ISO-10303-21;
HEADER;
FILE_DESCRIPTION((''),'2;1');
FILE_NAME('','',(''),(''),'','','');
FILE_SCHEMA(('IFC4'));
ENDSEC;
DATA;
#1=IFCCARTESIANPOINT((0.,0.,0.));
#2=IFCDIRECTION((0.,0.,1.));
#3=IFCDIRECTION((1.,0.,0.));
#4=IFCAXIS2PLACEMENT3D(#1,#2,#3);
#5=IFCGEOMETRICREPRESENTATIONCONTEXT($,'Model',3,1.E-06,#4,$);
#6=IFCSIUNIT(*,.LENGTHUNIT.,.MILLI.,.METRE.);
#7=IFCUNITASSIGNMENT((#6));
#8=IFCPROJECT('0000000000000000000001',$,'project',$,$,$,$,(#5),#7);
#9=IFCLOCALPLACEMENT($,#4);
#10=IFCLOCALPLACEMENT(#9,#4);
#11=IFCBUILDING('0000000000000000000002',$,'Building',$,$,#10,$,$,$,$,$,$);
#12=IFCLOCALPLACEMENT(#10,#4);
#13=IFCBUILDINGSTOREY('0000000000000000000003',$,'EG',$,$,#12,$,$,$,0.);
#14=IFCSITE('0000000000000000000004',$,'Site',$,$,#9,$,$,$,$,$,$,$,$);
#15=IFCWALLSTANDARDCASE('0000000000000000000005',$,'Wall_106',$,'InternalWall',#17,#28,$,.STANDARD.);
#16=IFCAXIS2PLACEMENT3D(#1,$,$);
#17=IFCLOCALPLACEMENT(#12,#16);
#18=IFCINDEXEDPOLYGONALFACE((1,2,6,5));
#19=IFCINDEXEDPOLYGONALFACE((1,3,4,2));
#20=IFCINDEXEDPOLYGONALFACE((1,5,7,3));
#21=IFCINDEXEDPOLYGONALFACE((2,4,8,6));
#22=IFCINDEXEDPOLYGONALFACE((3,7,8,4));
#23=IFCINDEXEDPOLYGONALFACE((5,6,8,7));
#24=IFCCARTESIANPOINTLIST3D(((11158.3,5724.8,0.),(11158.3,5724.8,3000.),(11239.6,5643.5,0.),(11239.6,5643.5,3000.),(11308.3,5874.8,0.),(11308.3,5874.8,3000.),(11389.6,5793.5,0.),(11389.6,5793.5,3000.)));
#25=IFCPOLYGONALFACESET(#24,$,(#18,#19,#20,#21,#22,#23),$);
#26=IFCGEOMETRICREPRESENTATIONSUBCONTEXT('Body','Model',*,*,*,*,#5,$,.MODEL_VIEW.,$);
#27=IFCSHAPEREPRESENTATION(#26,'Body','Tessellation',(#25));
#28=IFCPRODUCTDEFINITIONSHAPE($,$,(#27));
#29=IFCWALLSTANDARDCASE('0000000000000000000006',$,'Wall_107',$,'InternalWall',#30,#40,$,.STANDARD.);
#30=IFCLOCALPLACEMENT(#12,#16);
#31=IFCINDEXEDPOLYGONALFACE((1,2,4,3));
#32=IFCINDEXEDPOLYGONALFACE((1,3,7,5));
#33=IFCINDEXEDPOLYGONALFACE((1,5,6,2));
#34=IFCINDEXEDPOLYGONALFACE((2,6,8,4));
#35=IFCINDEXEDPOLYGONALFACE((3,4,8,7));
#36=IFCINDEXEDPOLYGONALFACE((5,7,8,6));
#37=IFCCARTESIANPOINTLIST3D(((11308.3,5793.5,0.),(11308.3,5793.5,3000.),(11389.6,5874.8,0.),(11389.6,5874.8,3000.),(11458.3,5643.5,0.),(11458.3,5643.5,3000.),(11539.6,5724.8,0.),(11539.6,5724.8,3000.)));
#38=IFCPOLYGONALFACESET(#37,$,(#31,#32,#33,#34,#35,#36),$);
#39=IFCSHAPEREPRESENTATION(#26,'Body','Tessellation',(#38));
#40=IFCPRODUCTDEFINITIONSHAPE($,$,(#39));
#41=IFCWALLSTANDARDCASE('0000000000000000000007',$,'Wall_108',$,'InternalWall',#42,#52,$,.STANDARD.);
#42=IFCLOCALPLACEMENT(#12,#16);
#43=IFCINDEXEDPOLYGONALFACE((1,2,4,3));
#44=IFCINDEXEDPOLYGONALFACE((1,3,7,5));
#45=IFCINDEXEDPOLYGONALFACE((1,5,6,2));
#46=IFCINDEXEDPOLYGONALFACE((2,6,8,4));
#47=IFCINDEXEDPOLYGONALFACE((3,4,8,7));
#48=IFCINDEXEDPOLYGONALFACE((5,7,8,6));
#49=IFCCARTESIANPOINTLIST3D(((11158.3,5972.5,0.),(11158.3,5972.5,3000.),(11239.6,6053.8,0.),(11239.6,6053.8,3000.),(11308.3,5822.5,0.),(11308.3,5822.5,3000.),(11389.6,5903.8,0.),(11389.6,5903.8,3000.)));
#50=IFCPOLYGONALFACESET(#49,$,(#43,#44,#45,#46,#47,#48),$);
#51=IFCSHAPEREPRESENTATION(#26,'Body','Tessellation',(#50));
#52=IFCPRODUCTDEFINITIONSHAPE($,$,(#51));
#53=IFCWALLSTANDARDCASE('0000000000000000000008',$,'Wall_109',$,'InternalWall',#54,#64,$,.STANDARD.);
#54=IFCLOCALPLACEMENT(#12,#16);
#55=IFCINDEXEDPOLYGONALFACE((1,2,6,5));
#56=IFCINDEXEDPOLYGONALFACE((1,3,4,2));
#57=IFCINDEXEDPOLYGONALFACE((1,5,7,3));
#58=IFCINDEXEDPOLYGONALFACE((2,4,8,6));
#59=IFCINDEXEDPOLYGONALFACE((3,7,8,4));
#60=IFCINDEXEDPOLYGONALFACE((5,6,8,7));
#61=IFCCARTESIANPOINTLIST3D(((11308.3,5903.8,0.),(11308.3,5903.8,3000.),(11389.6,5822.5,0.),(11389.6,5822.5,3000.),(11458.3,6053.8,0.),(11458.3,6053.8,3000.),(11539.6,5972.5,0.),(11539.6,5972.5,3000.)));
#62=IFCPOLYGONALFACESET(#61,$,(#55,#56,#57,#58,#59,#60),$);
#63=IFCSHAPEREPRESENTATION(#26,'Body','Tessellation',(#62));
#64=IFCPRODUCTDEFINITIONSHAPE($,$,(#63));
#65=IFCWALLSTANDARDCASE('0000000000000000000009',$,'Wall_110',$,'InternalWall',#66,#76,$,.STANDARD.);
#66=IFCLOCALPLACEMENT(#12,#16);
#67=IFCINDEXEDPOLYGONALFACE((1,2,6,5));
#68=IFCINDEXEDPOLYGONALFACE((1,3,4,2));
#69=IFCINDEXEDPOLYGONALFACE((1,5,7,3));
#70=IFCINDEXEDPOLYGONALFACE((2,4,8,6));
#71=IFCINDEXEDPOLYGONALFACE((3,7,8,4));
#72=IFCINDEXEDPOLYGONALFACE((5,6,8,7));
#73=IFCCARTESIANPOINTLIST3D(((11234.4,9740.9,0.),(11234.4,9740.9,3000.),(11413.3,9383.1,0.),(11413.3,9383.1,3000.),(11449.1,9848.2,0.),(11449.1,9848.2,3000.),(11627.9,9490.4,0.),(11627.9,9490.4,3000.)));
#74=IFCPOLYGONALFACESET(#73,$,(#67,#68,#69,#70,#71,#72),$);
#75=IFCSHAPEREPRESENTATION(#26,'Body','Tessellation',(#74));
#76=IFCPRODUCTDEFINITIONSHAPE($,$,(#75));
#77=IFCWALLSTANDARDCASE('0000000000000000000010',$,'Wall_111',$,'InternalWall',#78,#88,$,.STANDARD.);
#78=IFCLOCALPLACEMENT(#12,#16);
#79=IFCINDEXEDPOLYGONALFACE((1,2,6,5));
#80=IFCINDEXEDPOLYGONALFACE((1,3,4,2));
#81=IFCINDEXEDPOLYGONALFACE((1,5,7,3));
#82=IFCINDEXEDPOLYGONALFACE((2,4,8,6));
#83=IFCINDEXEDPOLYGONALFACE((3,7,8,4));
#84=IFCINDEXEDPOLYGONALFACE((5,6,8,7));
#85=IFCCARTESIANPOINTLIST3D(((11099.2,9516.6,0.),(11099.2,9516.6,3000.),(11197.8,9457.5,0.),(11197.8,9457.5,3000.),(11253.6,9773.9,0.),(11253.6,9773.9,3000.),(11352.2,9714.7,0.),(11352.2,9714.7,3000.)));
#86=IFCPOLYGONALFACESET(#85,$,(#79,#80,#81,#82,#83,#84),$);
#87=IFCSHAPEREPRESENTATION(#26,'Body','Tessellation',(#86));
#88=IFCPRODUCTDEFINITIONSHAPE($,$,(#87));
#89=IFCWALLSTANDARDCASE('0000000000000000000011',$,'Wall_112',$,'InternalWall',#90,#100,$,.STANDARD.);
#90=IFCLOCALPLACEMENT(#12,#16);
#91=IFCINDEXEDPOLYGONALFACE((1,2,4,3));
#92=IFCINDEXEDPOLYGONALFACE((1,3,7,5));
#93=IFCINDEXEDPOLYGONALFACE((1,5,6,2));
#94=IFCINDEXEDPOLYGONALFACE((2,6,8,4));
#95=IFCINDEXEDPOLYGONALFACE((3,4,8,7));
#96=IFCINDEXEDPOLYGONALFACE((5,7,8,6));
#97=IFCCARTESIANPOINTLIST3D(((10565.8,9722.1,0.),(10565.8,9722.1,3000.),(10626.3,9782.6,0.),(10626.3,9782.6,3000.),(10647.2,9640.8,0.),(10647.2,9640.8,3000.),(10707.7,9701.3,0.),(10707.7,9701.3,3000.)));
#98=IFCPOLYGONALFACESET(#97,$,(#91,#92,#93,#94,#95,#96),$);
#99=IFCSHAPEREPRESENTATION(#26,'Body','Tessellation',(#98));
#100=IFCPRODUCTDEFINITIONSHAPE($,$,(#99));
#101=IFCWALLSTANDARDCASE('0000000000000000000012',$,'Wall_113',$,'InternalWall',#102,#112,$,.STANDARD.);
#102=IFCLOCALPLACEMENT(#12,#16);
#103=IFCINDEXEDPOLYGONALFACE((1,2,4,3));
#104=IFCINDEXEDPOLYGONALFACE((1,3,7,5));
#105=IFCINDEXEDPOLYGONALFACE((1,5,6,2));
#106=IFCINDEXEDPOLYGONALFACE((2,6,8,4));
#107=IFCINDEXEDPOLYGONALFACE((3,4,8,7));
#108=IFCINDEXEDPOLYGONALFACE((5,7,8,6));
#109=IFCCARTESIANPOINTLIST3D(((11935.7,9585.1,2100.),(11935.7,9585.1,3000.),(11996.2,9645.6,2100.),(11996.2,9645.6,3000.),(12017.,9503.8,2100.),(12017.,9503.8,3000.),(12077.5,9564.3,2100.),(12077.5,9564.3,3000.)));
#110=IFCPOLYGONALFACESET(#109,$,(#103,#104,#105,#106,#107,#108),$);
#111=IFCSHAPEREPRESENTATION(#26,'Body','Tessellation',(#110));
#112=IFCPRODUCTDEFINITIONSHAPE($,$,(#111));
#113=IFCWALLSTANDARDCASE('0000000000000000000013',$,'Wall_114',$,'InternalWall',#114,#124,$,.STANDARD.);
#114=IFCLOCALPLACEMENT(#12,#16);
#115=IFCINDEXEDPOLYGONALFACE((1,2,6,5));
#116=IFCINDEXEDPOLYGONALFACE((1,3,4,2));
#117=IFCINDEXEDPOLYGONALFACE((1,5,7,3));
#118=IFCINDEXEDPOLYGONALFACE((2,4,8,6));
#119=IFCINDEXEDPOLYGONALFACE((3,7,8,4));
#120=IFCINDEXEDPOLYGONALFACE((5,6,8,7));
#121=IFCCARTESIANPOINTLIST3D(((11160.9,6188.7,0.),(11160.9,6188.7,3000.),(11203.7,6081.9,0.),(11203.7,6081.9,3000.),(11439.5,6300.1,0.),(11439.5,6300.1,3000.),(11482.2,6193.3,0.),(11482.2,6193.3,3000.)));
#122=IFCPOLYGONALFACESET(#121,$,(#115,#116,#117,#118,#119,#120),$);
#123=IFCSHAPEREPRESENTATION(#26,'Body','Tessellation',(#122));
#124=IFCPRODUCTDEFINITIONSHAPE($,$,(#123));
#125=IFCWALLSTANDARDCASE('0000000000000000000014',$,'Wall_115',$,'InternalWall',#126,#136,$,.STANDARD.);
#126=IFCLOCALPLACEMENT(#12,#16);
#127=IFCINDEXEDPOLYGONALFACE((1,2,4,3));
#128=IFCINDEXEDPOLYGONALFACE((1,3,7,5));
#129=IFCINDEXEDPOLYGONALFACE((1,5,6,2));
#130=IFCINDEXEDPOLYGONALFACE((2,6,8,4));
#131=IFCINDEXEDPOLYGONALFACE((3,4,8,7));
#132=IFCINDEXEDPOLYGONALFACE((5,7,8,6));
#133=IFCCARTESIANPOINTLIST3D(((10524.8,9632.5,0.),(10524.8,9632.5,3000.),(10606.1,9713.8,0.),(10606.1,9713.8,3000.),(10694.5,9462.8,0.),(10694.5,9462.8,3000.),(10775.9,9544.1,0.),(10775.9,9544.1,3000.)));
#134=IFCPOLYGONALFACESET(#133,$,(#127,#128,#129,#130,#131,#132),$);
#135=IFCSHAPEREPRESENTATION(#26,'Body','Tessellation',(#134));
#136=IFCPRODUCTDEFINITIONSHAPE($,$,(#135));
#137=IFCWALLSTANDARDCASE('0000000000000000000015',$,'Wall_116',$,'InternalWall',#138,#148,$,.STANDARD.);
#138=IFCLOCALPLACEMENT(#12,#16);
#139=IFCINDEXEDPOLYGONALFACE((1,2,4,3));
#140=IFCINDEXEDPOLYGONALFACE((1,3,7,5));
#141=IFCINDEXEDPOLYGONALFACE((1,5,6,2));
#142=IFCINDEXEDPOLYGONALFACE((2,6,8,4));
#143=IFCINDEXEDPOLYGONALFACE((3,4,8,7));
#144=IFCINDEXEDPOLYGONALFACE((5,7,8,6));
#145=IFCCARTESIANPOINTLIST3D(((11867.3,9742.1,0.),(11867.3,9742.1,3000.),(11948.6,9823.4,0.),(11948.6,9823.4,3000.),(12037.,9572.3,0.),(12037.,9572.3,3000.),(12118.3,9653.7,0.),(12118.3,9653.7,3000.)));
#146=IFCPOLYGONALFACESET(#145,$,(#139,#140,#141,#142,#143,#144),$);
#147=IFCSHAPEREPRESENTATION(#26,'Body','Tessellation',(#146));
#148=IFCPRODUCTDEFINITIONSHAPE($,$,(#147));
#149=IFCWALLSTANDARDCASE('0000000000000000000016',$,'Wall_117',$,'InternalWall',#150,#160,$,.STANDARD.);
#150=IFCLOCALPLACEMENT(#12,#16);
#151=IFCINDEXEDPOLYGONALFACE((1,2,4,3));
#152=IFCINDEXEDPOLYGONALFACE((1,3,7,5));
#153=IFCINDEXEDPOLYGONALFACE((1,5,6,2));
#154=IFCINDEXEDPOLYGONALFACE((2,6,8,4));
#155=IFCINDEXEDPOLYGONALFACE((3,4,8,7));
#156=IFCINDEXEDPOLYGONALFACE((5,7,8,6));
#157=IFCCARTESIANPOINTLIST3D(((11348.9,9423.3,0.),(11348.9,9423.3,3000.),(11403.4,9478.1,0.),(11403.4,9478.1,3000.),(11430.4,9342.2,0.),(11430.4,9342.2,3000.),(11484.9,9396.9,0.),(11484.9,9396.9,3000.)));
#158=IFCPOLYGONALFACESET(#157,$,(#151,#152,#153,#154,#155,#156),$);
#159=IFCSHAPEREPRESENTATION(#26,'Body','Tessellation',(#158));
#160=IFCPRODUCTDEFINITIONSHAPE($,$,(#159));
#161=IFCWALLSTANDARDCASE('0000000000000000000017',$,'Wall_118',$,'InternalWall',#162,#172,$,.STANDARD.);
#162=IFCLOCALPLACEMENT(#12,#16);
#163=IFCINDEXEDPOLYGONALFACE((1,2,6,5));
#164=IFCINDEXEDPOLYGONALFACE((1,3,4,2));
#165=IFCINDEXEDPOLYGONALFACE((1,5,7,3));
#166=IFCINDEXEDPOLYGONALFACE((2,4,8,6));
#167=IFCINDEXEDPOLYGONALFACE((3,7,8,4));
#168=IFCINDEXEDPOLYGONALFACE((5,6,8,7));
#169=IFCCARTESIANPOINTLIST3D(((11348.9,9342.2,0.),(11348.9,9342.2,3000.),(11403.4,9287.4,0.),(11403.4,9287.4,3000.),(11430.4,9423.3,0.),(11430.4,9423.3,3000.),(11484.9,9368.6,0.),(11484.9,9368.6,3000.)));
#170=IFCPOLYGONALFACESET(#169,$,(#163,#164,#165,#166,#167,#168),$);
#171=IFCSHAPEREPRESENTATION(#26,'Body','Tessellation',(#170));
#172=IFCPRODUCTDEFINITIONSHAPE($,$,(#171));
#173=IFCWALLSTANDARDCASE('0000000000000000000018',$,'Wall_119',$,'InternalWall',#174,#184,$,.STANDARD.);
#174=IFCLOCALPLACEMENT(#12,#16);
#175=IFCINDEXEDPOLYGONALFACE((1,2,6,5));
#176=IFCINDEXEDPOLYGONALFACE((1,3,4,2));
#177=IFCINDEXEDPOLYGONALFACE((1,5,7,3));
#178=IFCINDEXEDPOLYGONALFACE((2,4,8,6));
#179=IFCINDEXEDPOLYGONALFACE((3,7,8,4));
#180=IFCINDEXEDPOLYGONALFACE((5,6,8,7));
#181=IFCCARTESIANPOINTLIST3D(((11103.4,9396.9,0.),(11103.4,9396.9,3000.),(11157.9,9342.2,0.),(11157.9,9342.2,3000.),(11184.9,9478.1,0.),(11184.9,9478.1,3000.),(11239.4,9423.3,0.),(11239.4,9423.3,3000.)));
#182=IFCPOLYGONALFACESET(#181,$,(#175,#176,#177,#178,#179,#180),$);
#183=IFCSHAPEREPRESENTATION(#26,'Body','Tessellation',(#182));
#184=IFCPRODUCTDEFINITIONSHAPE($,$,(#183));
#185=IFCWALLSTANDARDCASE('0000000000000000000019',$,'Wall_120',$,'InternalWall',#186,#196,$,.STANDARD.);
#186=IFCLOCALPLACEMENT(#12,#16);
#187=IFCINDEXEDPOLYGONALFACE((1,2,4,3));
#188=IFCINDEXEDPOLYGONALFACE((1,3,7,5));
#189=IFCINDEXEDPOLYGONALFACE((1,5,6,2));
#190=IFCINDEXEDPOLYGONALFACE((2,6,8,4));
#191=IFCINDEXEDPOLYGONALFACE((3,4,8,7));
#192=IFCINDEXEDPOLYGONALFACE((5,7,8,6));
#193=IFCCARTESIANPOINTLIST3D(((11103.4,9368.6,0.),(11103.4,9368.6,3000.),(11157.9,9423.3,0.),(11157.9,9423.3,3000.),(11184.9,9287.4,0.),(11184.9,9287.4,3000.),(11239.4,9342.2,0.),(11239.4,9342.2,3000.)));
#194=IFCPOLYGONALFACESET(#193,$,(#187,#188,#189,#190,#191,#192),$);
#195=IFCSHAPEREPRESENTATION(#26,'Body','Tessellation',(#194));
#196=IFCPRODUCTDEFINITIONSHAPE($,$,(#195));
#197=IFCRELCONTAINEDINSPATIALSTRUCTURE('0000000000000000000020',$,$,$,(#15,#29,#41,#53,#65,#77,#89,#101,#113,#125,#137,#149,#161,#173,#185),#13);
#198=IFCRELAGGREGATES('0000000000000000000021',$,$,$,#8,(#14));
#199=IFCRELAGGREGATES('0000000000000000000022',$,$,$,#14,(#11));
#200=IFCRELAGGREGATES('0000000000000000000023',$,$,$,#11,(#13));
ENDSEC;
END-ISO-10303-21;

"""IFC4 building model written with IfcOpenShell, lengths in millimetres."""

from ifc_helpers import new_model, si_unit, frame, origin_with_axes, place, context, subcontext, project, spatial, rectangle, extrude, element, save


model = new_model("IFC4")

# Units and contexts
model_context = context("Model", 3, precision=1e-06, world=origin_with_axes())
body_context = subcontext(model_context, "Body", "Model", "MODEL_VIEW")
ifc_project = project(units=[si_unit("LENGTHUNIT", "METRE", prefix="MILLI")], contexts=[model_context])

# Site, building, storey
site_placement = place(None, origin_with_axes())
site = spatial("IfcSite", under=ifc_project, at=site_placement, Name="Site")
building_placement = place(site_placement, origin_with_axes())
building = spatial("IfcBuilding", under=site, at=building_placement, Name="Building")
storey_placement = place(building_placement, origin_with_axes())
storey = spatial("IfcBuildingStorey", under=building, at=storey_placement, Name="EG", Elevation=0.0)

# Walls
wall_1_placement = place(storey_placement, origin_with_axes())
element("IfcWallStandardCase", 1, at=wall_1_placement, inside=storey, Name="Wall_106", ObjectType="InternalWall", PredefinedType="STANDARD", context=body_context, shape_type="SweptSolid", body=[
    extrude(rectangle(XDim=212.1, YDim=115.0), frame((11274.0, 5759.2, 0.0), z_axis=(0.0, 0.0, 1.0), x_axis=(-0.707107, -0.707107, 0.0)), (0.0, 0.0, 1.0), 3000.0),
])
wall_2_placement = place(storey_placement, origin_with_axes())
element("IfcWallStandardCase", 2, at=wall_2_placement, inside=storey, Name="Wall_107", ObjectType="InternalWall", PredefinedType="STANDARD", context=body_context, shape_type="SweptSolid", body=[
    extrude(rectangle(XDim=212.1, YDim=115.0), frame((11424.0, 5759.2, 0.0), z_axis=(0.0, 0.0, 1.0), x_axis=(0.707107, -0.707107, 0.0)), (0.0, 0.0, 1.0), 3000.0),
])
wall_3_placement = place(storey_placement, origin_with_axes())
element("IfcWallStandardCase", 3, at=wall_3_placement, inside=storey, Name="Wall_108", ObjectType="InternalWall", PredefinedType="STANDARD", context=body_context, shape_type="SweptSolid", body=[
    extrude(rectangle(XDim=212.1, YDim=115.0), frame((11274.0, 5938.2, 0.0), z_axis=(0.0, 0.0, 1.0), x_axis=(-0.707107, 0.707107, 0.0)), (0.0, 0.0, 1.0), 3000.0),
])
wall_4_placement = place(storey_placement, origin_with_axes())
element("IfcWallStandardCase", 4, at=wall_4_placement, inside=storey, Name="Wall_109", ObjectType="InternalWall", PredefinedType="STANDARD", context=body_context, shape_type="SweptSolid", body=[
    extrude(rectangle(XDim=212.1, YDim=115.0), frame((11424.0, 5938.2, 0.0), z_axis=(0.0, 0.0, 1.0), x_axis=(0.707107, 0.707107, 0.0)), (0.0, 0.0, 1.0), 3000.0),
])
wall_5_placement = place(storey_placement, origin_with_axes())
element("IfcWallStandardCase", 5, at=wall_5_placement, inside=storey, Name="Wall_110", ObjectType="InternalWall", PredefinedType="STANDARD", context=body_context, shape_type="SweptSolid", body=[
    extrude(rectangle(XDim=400.0, YDim=240.0), frame((11431.2, 9615.7, 0.0), z_axis=(0.0, 0.0, 1.0), x_axis=(-0.447214, 0.894427, 0.0)), (0.0, 0.0, 1.0), 3000.0),
])
wall_6_placement = place(storey_placement, origin_with_axes())
element("IfcWallStandardCase", 6, at=wall_6_placement, inside=storey, Name="Wall_111", ObjectType="InternalWall", PredefinedType="STANDARD", context=body_context, shape_type="SweptSolid", body=[
    extrude(rectangle(XDim=300.0, YDim=115.0), frame((11225.7, 9615.7, 0.0), z_axis=(0.0, 0.0, 1.0), x_axis=(0.514496, 0.857493, 0.0)), (0.0, 0.0, 1.0), 3000.0),
])
wall_7_placement = place(storey_placement, origin_with_axes())
element("IfcWallStandardCase", 7, at=wall_7_placement, inside=storey, Name="Wall_112", ObjectType="InternalWall", PredefinedType="STANDARD", context=body_context, shape_type="SweptSolid", body=[
    extrude(rectangle(XDim=85.6, YDim=115.0), frame((10636.7, 9711.7, 0.0), z_axis=(0.0, 0.0, 1.0), x_axis=(-0.707107, -0.707107, 0.0)), (0.0, 0.0, 1.0), 3000.0),
])

# Wall, opening
wall_8_placement = place(storey_placement, origin_with_axes())
wall_8 = element("IfcWallStandardCase", 8, at=wall_8_placement, inside=storey, Name="Wall_113", ObjectType="InternalWall", PredefinedType="STANDARD", context=body_context, shape_type="SweptSolid", body=[
    extrude(rectangle(XDim=85.6, YDim=115.0), frame((12006.6, 9574.7, 0.0), z_axis=(0.0, 0.0, 1.0), x_axis=(-0.707107, -0.707107, 0.0)), (0.0, 0.0, 1.0), 3000.0),
])
opening_1_placement = place(wall_8_placement, origin_with_axes())
element("IfcOpeningElement", 9, at=opening_1_placement, inside=storey, cuts=wall_8, context=body_context, shape_type="SweptSolid", body=[
    extrude(rectangle(XDim=450.0, YDim=115.0), frame((12006.5, 9574.6, 0.0), z_axis=(0.0, 0.0, 1.0), x_axis=(-0.707107, -0.707107, 0.0)), (0.0, 0.0, 1.0), 2100.0),
])

# Walls
wall_9_placement = place(storey_placement, origin_with_axes())
element("IfcWallStandardCase", 10, at=wall_9_placement, inside=storey, Name="Wall_114", ObjectType="InternalWall", PredefinedType="STANDARD", context=body_context, shape_type="SweptSolid", body=[
    extrude(rectangle(XDim=300.0, YDim=115.0), frame((11321.6, 6191.0, 0.0), z_axis=(0.0, 0.0, 1.0), x_axis=(0.928477, 0.371391, 0.0)), (0.0, 0.0, 1.0), 3000.0),
])
wall_10_placement = place(storey_placement, origin_with_axes())
element("IfcWallStandardCase", 11, at=wall_10_placement, inside=storey, Name="Wall_115", ObjectType="InternalWall", PredefinedType="STANDARD", context=body_context, shape_type="SweptSolid", body=[
    extrude(rectangle(XDim=240.0, YDim=115.0), frame((10650.3, 9588.3, 0.0), z_axis=(0.0, 0.0, 1.0), x_axis=(-0.707107, 0.707107, 0.0)), (0.0, 0.0, 1.0), 3000.0),
])
wall_11_placement = place(storey_placement, origin_with_axes())
element("IfcWallStandardCase", 12, at=wall_11_placement, inside=storey, Name="Wall_116", ObjectType="InternalWall", PredefinedType="STANDARD", context=body_context, shape_type="SweptSolid", body=[
    extrude(rectangle(XDim=240.0, YDim=115.0), frame((11992.8, 9697.9, 0.0), z_axis=(0.0, 0.0, 1.0), x_axis=(-0.707107, 0.707107, 0.0)), (0.0, 0.0, 1.0), 3000.0),
])
wall_12_placement = place(storey_placement, origin_with_axes())
element("IfcWallStandardCase", 13, at=wall_12_placement, inside=storey, Name="Wall_117", ObjectType="InternalWall", PredefinedType="STANDARD", context=body_context, shape_type="SweptSolid", body=[
    extrude(rectangle(XDim=77.3, YDim=115.0), frame((11416.9, 9410.1, 0.0), z_axis=(0.0, 0.0, 1.0), x_axis=(0.705487, 0.708723, 0.0)), (0.0, 0.0, 1.0), 3000.0),
])
wall_13_placement = place(storey_placement, origin_with_axes())
element("IfcWallStandardCase", 14, at=wall_13_placement, inside=storey, Name="Wall_118", ObjectType="InternalWall", PredefinedType="STANDARD", context=body_context, shape_type="SweptSolid", body=[
    extrude(rectangle(XDim=77.3, YDim=115.0), frame((11416.9, 9355.4, 0.0), z_axis=(0.0, 0.0, 1.0), x_axis=(0.705487, -0.708723, 0.0)), (0.0, 0.0, 1.0), 3000.0),
])
wall_14_placement = place(storey_placement, origin_with_axes())
element("IfcWallStandardCase", 15, at=wall_14_placement, inside=storey, Name="Wall_119", ObjectType="InternalWall", PredefinedType="STANDARD", context=body_context, shape_type="SweptSolid", body=[
    extrude(rectangle(XDim=77.3, YDim=115.0), frame((11171.4, 9410.1, 0.0), z_axis=(0.0, 0.0, 1.0), x_axis=(-0.705487, 0.708723, 0.0)), (0.0, 0.0, 1.0), 3000.0),
])
wall_15_placement = place(storey_placement, origin_with_axes())
element("IfcWallStandardCase", 16, at=wall_15_placement, inside=storey, Name="Wall_120", ObjectType="InternalWall", PredefinedType="STANDARD", context=body_context, shape_type="SweptSolid", body=[
    extrude(rectangle(XDim=77.3, YDim=115.0), frame((11171.4, 9355.4, 0.0), z_axis=(0.0, 0.0, 1.0), x_axis=(-0.705487, -0.708723, 0.0)), (0.0, 0.0, 1.0), 3000.0),
])

save(model, "model.ifc")
